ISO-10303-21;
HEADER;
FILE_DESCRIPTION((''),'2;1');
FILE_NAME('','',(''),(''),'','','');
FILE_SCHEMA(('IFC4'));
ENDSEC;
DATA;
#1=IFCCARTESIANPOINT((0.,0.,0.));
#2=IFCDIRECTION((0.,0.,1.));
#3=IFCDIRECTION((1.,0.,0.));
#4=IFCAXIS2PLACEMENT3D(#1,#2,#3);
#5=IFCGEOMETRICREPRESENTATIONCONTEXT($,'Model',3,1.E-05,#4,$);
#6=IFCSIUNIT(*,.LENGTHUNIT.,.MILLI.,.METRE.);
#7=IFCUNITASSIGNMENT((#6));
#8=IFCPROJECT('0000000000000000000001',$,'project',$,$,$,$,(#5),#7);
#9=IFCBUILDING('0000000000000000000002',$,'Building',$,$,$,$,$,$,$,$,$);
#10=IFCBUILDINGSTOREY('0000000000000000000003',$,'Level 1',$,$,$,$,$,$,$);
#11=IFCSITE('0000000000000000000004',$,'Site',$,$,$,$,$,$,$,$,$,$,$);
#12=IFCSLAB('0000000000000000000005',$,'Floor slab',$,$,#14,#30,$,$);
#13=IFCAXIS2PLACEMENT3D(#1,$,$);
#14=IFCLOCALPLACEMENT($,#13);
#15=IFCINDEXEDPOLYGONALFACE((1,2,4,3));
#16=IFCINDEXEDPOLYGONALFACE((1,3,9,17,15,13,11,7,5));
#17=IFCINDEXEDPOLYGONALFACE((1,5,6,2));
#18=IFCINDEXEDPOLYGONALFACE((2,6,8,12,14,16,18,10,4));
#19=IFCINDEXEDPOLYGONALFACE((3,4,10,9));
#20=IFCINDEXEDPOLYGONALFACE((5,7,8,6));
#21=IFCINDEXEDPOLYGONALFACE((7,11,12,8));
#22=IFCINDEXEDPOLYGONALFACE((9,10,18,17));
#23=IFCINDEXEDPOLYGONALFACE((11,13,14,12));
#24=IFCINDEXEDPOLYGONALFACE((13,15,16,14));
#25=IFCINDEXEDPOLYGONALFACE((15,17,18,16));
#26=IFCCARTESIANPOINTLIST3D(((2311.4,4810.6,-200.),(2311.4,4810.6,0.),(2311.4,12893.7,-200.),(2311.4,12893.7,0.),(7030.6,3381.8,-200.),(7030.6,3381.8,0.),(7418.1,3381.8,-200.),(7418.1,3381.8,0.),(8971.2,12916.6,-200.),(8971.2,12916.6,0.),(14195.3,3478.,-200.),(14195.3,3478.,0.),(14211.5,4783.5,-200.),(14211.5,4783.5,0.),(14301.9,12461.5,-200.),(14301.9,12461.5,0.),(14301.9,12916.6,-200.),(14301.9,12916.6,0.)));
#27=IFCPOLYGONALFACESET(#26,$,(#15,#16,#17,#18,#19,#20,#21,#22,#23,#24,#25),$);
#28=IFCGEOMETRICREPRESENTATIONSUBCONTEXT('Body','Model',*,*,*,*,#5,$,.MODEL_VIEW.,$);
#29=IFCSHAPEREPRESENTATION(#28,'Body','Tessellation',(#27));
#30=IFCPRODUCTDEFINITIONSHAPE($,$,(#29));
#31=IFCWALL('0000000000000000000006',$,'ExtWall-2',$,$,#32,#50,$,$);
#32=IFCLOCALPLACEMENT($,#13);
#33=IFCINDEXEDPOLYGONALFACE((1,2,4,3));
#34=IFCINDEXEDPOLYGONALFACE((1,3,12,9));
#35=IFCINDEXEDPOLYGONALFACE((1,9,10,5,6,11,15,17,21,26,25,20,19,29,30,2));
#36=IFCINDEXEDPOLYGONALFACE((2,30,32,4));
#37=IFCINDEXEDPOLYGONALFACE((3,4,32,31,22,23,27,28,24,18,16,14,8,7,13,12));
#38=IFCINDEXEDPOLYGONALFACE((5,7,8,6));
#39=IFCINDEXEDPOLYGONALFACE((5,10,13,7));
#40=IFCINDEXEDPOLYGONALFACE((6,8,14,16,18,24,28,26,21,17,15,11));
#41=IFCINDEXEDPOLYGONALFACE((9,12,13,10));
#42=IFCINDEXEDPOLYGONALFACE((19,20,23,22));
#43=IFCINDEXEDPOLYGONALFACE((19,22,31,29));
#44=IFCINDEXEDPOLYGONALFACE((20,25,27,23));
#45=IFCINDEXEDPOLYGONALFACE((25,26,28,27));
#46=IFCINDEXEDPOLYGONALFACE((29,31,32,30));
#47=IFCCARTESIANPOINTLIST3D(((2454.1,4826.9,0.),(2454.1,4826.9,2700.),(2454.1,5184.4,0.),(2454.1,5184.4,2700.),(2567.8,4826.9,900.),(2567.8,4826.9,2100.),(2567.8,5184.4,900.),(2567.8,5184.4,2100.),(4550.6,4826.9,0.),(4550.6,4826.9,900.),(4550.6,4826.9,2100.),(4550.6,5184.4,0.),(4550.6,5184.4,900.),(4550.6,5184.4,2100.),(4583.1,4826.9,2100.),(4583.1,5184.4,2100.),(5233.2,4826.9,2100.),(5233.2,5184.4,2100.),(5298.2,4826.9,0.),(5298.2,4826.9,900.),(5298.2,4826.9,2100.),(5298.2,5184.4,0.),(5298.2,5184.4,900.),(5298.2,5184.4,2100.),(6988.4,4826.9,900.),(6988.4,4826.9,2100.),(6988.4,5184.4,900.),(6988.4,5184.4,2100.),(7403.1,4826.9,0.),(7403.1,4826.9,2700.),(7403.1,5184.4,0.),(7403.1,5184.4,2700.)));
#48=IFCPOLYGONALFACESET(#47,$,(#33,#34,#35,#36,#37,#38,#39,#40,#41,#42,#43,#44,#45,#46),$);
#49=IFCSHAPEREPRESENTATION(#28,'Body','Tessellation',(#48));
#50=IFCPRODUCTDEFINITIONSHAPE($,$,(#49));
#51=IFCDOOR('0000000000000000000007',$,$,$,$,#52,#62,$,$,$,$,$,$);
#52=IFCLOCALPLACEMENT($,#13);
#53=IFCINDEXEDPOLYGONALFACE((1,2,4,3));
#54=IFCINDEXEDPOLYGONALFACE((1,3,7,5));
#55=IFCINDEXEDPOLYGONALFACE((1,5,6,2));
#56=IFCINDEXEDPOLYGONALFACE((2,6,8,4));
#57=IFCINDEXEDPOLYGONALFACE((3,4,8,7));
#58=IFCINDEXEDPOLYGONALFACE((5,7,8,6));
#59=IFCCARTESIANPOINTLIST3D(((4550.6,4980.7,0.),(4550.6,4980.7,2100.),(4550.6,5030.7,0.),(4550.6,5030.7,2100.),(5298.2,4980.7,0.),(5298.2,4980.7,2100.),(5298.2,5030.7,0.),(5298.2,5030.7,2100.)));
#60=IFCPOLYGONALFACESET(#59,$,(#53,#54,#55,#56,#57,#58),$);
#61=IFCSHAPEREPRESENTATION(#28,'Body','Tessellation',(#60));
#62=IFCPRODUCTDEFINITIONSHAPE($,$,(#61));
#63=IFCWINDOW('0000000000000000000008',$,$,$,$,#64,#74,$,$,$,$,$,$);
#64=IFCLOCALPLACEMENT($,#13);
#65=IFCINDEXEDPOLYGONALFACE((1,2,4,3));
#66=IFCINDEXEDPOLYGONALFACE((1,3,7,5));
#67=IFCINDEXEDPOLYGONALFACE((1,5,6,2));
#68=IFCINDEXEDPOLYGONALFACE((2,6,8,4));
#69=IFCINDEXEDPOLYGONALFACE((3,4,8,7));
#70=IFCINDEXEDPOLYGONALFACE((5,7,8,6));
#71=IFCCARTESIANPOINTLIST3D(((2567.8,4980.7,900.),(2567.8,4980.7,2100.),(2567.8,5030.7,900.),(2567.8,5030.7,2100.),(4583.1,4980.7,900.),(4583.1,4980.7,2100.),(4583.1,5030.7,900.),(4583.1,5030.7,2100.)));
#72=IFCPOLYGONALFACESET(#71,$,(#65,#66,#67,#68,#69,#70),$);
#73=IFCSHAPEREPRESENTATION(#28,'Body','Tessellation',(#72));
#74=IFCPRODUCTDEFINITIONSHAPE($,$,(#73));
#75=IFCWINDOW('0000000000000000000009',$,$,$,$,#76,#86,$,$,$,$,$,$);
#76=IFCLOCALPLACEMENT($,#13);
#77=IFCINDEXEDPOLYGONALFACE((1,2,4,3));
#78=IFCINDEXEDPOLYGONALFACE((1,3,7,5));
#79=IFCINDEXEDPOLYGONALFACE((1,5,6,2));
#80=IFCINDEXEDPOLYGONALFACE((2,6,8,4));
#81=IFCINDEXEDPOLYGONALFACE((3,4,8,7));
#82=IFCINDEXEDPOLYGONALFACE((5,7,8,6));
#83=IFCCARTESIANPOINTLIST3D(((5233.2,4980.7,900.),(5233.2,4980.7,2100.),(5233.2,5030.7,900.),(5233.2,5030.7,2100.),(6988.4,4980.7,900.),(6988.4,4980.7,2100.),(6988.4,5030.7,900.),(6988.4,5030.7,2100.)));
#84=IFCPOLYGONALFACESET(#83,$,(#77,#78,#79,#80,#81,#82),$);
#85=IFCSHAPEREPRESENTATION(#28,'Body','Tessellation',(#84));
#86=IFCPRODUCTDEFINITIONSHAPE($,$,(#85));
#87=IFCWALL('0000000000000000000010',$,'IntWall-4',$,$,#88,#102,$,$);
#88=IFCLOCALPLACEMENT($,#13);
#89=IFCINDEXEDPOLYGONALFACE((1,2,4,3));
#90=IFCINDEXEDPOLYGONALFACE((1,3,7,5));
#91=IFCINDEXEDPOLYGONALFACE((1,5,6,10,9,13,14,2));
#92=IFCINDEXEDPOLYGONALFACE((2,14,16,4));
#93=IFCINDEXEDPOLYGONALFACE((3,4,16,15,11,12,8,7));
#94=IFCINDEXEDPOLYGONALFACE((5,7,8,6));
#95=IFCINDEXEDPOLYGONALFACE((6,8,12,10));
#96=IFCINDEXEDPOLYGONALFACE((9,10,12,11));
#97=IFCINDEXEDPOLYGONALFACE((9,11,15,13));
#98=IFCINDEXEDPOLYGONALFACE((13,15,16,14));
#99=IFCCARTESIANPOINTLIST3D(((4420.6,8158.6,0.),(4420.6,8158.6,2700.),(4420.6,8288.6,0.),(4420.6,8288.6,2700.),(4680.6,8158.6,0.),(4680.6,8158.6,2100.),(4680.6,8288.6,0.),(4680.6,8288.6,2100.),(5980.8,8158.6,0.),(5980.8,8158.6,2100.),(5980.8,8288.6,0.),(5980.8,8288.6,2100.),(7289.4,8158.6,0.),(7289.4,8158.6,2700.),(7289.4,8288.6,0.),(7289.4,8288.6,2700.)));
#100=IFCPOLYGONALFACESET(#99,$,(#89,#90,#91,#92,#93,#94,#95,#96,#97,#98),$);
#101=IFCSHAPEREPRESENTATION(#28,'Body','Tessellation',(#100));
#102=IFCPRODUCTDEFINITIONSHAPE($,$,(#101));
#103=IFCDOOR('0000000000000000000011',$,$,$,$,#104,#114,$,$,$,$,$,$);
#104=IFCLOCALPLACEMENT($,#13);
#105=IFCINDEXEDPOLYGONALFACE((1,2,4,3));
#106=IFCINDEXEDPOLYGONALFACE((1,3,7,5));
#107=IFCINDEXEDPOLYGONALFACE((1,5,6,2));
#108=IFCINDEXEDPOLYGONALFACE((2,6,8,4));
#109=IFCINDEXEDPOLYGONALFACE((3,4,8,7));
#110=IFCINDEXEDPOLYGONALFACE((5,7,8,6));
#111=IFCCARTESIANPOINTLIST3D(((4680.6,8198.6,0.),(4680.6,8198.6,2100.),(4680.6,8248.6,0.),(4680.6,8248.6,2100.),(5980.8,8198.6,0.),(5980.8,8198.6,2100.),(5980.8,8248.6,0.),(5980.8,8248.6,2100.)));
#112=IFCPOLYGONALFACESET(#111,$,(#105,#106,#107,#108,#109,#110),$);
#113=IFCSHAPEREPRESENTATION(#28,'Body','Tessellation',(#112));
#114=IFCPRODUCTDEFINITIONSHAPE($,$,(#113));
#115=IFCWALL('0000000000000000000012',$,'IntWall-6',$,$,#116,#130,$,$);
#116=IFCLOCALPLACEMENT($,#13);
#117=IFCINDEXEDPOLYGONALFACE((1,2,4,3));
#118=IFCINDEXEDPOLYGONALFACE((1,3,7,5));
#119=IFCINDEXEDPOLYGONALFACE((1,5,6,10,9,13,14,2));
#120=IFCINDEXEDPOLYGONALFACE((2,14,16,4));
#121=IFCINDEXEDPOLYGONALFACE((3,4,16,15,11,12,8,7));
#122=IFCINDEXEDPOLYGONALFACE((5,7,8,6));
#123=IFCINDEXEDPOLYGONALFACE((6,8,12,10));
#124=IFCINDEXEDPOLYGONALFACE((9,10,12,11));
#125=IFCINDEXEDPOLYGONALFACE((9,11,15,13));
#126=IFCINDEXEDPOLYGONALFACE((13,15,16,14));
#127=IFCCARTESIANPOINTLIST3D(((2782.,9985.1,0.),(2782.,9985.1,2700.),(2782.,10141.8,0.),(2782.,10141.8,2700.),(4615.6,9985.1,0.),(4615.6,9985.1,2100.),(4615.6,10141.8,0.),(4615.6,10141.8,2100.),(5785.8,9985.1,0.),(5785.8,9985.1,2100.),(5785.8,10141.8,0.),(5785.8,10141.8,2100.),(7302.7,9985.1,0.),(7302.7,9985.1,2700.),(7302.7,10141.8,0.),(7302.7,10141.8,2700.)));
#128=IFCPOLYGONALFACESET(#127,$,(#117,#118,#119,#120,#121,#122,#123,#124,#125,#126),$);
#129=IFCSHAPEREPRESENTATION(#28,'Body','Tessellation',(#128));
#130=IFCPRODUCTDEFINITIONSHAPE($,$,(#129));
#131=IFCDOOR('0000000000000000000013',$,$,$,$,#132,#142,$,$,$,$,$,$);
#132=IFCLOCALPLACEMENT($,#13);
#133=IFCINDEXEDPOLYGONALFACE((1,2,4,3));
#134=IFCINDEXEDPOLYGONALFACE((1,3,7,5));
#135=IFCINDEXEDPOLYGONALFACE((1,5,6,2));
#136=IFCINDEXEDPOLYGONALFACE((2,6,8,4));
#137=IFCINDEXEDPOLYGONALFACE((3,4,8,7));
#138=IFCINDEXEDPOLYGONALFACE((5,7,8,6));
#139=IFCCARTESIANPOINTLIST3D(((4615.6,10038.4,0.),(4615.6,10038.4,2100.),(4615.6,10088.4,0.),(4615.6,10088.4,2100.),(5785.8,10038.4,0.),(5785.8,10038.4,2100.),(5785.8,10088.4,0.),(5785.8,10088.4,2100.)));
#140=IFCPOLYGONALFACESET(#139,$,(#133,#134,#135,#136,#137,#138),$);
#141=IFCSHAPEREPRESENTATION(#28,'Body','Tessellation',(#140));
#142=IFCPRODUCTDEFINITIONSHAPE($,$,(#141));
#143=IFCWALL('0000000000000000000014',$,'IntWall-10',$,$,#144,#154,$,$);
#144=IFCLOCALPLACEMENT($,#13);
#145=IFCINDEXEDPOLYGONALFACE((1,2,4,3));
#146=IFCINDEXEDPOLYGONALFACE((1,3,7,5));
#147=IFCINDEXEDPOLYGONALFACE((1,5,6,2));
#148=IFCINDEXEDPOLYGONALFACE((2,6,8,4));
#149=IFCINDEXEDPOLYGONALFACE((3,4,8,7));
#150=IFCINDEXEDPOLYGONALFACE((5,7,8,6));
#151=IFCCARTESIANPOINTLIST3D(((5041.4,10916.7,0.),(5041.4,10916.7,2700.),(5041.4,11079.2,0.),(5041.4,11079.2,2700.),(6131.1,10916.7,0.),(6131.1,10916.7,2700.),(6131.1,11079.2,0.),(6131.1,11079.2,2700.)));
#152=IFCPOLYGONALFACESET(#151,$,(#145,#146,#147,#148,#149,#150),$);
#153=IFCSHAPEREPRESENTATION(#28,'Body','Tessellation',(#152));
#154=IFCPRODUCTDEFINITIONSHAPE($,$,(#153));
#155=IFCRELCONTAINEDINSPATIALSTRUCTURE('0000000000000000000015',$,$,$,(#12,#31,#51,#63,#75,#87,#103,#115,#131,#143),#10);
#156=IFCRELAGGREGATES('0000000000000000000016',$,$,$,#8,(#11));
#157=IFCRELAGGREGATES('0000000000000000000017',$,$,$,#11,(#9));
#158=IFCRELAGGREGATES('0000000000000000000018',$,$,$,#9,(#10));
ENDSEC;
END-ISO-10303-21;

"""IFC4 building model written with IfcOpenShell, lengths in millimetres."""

from ifc_helpers import new_model, si_unit, frame, origin_with_axes, place, context, subcontext, project, spatial, indexed_curve, outline, extrude, element, fill, save


model = new_model("IFC4")

# Units and contexts
model_context = context("Model", 3, precision=1e-05, world=origin_with_axes())
body_context = subcontext(model_context, "Body", "Model", "MODEL_VIEW")
ifc_project = project(units=[si_unit("LENGTHUNIT", "METRE", prefix="MILLI")], contexts=[model_context])

# Site, building, storey
site = spatial("IfcSite", under=ifc_project, Name="Site")
building = spatial("IfcBuilding", under=site, Name="Building")
storey = spatial("IfcBuildingStorey", under=building, Name="Level 1")

# Slab
slab_placement = place(None, frame((0.0, 0.0, -200.0), z_axis=(0.0, 0.0, 1.0), x_axis=(1.0, 0.0, 0.0)))
element("IfcSlab", 1, at=slab_placement, inside=storey, Name="Floor slab", context=body_context, shape_type="SweptSolid", body=[
    extrude(outline(indexed_curve([(7030.6, 3381.8), (2311.4, 4810.6), (2311.4, 12893.7), (8971.2, 12916.6), (14301.9, 12916.6), (14301.9, 12461.5), (14211.5, 4783.5), (14195.3, 3478.0), (7418.1, 3381.8)])), None, (0.0, 0.0, 1.0), 200.0),
])

# Wall, openings, door, windows
wall_1_placement = place(None, frame((2454.1, 5005.7, 0.0), z_axis=(0.0, 0.0, 1.0), x_axis=(1.0, 0.0, 0.0)))
wall_1 = element("IfcWall", 2, at=wall_1_placement, inside=storey, Name="ExtWall-2", context=body_context, shape_type="SweptSolid", body=[
    extrude(outline(indexed_curve([(0.0, 0.0), (0.0, 357.5), (4949.1, 357.5), (4949.1, 0.0), (0.0, 0.0)], self_intersect=False)), frame((0.0, -178.8, 0.0), z_axis=(0.0, 0.0, 1.0), x_axis=(1.0, 0.0, 0.0)), (0.0, 0.0, 1.0), 2700.0),
])
opening_1_placement = place(wall_1_placement, frame((2096.5, 0.0, 0.0), z_axis=(0.0, 0.0, 1.0), x_axis=(1.0, 0.0, 0.0)))
opening_1 = element("IfcOpeningElement", 3, at=opening_1_placement, cuts=wall_1, context=body_context, shape_type="SweptSolid", body=[
    extrude(outline(indexed_curve([(0.0, 0.0), (0.0, 457.5), (747.6, 457.5), (747.6, 0.0), (0.0, 0.0)], self_intersect=False)), frame((0.0, -228.8, 0.0), z_axis=(0.0, 0.0, 1.0), x_axis=(1.0, 0.0, 0.0)), (0.0, 0.0, 1.0), 2100.0),
])
opening_2_placement = place(wall_1_placement, frame((113.8, 0.0, 900.0), z_axis=(0.0, 0.0, 1.0), x_axis=(1.0, 0.0, 0.0)))
opening_2 = element("IfcOpeningElement", 4, at=opening_2_placement, cuts=wall_1, context=body_context, shape_type="SweptSolid", body=[
    extrude(outline(indexed_curve([(0.0, 0.0), (0.0, 457.5), (2015.3, 457.5), (2015.3, 0.0), (0.0, 0.0)], self_intersect=False)), frame((0.0, -228.8, 0.0), z_axis=(0.0, 0.0, 1.0), x_axis=(1.0, 0.0, 0.0)), (0.0, 0.0, 1.0), 1200.0),
])
opening_3_placement = place(wall_1_placement, frame((2779.1, 0.0, 900.0), z_axis=(0.0, 0.0, 1.0), x_axis=(1.0, 0.0, 0.0)))
opening_3 = element("IfcOpeningElement", 5, at=opening_3_placement, cuts=wall_1, context=body_context, shape_type="SweptSolid", body=[
    extrude(outline(indexed_curve([(0.0, 0.0), (0.0, 457.5), (1755.2, 457.5), (1755.2, 0.0), (0.0, 0.0)], self_intersect=False)), frame((0.0, -228.8, 0.0), z_axis=(0.0, 0.0, 1.0), x_axis=(1.0, 0.0, 0.0)), (0.0, 0.0, 1.0), 1200.0),
])
door_1_placement = place(opening_1_placement, origin_with_axes())
door_1 = element("IfcDoor", 6, at=door_1_placement, inside=storey, context=body_context, shape_type="SweptSolid", body=[
    extrude(outline(indexed_curve([(0.0, 0.0), (0.0, 50.0), (747.6, 50.0), (747.6, 0.0), (0.0, 0.0)], self_intersect=False)), frame((0.0, -25.0, 0.0), z_axis=(0.0, 0.0, 1.0), x_axis=(1.0, 0.0, 0.0)), (0.0, 0.0, 1.0), 2100.0),
])
fill(opening_1, door_1)
window_1_placement = place(opening_2_placement, origin_with_axes())
window_1 = element("IfcWindow", 7, at=window_1_placement, inside=storey, context=body_context, shape_type="SweptSolid", body=[
    extrude(outline(indexed_curve([(0.0, 0.0), (0.0, 50.0), (2015.3, 50.0), (2015.3, 0.0), (0.0, 0.0)], self_intersect=False)), frame((0.0, -25.0, 0.0), z_axis=(0.0, 0.0, 1.0), x_axis=(1.0, 0.0, 0.0)), (0.0, 0.0, 1.0), 1200.0),
])
fill(opening_2, window_1)
window_2_placement = place(opening_3_placement, origin_with_axes())
window_2 = element("IfcWindow", 8, at=window_2_placement, inside=storey, context=body_context, shape_type="SweptSolid", body=[
    extrude(outline(indexed_curve([(0.0, 0.0), (0.0, 50.0), (1755.2, 50.0), (1755.2, 0.0), (0.0, 0.0)], self_intersect=False)), frame((0.0, -25.0, 0.0), z_axis=(0.0, 0.0, 1.0), x_axis=(1.0, 0.0, 0.0)), (0.0, 0.0, 1.0), 1200.0),
])
fill(opening_3, window_2)

# Walls, openings, doors
wall_2_placement = place(None, frame((4420.6, 8223.6, 0.0), z_axis=(0.0, 0.0, 1.0), x_axis=(1.0, 0.0, 0.0)))
wall_2 = element("IfcWall", 9, at=wall_2_placement, inside=storey, Name="IntWall-4", context=body_context, shape_type="SweptSolid", body=[
    extrude(outline(indexed_curve([(0.0, 0.0), (0.0, 130.0), (2868.8, 130.0), (2868.8, 0.0), (0.0, 0.0)], self_intersect=False)), frame((0.0, -65.0, 0.0), z_axis=(0.0, 0.0, 1.0), x_axis=(1.0, 0.0, 0.0)), (0.0, 0.0, 1.0), 2700.0),
])
opening_4_placement = place(wall_2_placement, frame((260.0, 0.0, 0.0), z_axis=(0.0, 0.0, 1.0), x_axis=(1.0, 0.0, 0.0)))
opening_4 = element("IfcOpeningElement", 10, at=opening_4_placement, cuts=wall_2, context=body_context, shape_type="SweptSolid", body=[
    extrude(outline(indexed_curve([(0.0, 0.0), (0.0, 230.0), (1300.2, 230.0), (1300.2, 0.0), (0.0, 0.0)], self_intersect=False)), frame((0.0, -115.0, 0.0), z_axis=(0.0, 0.0, 1.0), x_axis=(1.0, 0.0, 0.0)), (0.0, 0.0, 1.0), 2100.0),
])
door_2_placement = place(opening_4_placement, origin_with_axes())
door_2 = element("IfcDoor", 11, at=door_2_placement, inside=storey, context=body_context, shape_type="SweptSolid", body=[
    extrude(outline(indexed_curve([(0.0, 0.0), (0.0, 50.0), (1300.2, 50.0), (1300.2, 0.0), (0.0, 0.0)], self_intersect=False)), frame((0.0, -25.0, 0.0), z_axis=(0.0, 0.0, 1.0), x_axis=(1.0, 0.0, 0.0)), (0.0, 0.0, 1.0), 2100.0),
])
fill(opening_4, door_2)
wall_3_placement = place(None, frame((2782.0, 10063.4, 0.0), z_axis=(0.0, 0.0, 1.0), x_axis=(1.0, 0.0, 0.0)))
wall_3 = element("IfcWall", 12, at=wall_3_placement, inside=storey, Name="IntWall-6", context=body_context, shape_type="SweptSolid", body=[
    extrude(outline(indexed_curve([(0.0, 0.0), (0.0, 156.7), (4520.7, 156.7), (4520.7, 0.0), (0.0, 0.0)], self_intersect=False)), frame((0.0, -78.3, 0.0), z_axis=(0.0, 0.0, 1.0), x_axis=(1.0, 0.0, 0.0)), (0.0, 0.0, 1.0), 2700.0),
])
opening_5_placement = place(wall_3_placement, frame((1833.6, 0.0, 0.0), z_axis=(0.0, 0.0, 1.0), x_axis=(1.0, 0.0, 0.0)))
opening_5 = element("IfcOpeningElement", 13, at=opening_5_placement, cuts=wall_3, context=body_context, shape_type="SweptSolid", body=[
    extrude(outline(indexed_curve([(0.0, 0.0), (0.0, 256.7), (1170.2, 256.7), (1170.2, 0.0), (0.0, 0.0)], self_intersect=False)), frame((0.0, -128.3, 0.0), z_axis=(0.0, 0.0, 1.0), x_axis=(1.0, 0.0, 0.0)), (0.0, 0.0, 1.0), 2100.0),
])
door_3_placement = place(opening_5_placement, origin_with_axes())
door_3 = element("IfcDoor", 14, at=door_3_placement, inside=storey, context=body_context, shape_type="SweptSolid", body=[
    extrude(outline(indexed_curve([(0.0, 0.0), (0.0, 50.0), (1170.2, 50.0), (1170.2, 0.0), (0.0, 0.0)], self_intersect=False)), frame((0.0, -25.0, 0.0), z_axis=(0.0, 0.0, 1.0), x_axis=(1.0, 0.0, 0.0)), (0.0, 0.0, 1.0), 2100.0),
])
fill(opening_5, door_3)

# Wall
wall_4_placement = place(None, frame((5041.4, 10998.0, 0.0), z_axis=(0.0, 0.0, 1.0), x_axis=(1.0, 0.0, 0.0)))
element("IfcWall", 15, at=wall_4_placement, inside=storey, Name="IntWall-10", context=body_context, shape_type="SweptSolid", body=[
    extrude(outline(indexed_curve([(0.0, 0.0), (0.0, 162.5), (1089.7, 162.5), (1089.7, 0.0), (0.0, 0.0)], self_intersect=False)), frame((0.0, -81.3, 0.0), z_axis=(0.0, 0.0, 1.0), x_axis=(1.0, 0.0, 0.0)), (0.0, 0.0, 1.0), 2700.0),
])

save(model, "model.ifc")
